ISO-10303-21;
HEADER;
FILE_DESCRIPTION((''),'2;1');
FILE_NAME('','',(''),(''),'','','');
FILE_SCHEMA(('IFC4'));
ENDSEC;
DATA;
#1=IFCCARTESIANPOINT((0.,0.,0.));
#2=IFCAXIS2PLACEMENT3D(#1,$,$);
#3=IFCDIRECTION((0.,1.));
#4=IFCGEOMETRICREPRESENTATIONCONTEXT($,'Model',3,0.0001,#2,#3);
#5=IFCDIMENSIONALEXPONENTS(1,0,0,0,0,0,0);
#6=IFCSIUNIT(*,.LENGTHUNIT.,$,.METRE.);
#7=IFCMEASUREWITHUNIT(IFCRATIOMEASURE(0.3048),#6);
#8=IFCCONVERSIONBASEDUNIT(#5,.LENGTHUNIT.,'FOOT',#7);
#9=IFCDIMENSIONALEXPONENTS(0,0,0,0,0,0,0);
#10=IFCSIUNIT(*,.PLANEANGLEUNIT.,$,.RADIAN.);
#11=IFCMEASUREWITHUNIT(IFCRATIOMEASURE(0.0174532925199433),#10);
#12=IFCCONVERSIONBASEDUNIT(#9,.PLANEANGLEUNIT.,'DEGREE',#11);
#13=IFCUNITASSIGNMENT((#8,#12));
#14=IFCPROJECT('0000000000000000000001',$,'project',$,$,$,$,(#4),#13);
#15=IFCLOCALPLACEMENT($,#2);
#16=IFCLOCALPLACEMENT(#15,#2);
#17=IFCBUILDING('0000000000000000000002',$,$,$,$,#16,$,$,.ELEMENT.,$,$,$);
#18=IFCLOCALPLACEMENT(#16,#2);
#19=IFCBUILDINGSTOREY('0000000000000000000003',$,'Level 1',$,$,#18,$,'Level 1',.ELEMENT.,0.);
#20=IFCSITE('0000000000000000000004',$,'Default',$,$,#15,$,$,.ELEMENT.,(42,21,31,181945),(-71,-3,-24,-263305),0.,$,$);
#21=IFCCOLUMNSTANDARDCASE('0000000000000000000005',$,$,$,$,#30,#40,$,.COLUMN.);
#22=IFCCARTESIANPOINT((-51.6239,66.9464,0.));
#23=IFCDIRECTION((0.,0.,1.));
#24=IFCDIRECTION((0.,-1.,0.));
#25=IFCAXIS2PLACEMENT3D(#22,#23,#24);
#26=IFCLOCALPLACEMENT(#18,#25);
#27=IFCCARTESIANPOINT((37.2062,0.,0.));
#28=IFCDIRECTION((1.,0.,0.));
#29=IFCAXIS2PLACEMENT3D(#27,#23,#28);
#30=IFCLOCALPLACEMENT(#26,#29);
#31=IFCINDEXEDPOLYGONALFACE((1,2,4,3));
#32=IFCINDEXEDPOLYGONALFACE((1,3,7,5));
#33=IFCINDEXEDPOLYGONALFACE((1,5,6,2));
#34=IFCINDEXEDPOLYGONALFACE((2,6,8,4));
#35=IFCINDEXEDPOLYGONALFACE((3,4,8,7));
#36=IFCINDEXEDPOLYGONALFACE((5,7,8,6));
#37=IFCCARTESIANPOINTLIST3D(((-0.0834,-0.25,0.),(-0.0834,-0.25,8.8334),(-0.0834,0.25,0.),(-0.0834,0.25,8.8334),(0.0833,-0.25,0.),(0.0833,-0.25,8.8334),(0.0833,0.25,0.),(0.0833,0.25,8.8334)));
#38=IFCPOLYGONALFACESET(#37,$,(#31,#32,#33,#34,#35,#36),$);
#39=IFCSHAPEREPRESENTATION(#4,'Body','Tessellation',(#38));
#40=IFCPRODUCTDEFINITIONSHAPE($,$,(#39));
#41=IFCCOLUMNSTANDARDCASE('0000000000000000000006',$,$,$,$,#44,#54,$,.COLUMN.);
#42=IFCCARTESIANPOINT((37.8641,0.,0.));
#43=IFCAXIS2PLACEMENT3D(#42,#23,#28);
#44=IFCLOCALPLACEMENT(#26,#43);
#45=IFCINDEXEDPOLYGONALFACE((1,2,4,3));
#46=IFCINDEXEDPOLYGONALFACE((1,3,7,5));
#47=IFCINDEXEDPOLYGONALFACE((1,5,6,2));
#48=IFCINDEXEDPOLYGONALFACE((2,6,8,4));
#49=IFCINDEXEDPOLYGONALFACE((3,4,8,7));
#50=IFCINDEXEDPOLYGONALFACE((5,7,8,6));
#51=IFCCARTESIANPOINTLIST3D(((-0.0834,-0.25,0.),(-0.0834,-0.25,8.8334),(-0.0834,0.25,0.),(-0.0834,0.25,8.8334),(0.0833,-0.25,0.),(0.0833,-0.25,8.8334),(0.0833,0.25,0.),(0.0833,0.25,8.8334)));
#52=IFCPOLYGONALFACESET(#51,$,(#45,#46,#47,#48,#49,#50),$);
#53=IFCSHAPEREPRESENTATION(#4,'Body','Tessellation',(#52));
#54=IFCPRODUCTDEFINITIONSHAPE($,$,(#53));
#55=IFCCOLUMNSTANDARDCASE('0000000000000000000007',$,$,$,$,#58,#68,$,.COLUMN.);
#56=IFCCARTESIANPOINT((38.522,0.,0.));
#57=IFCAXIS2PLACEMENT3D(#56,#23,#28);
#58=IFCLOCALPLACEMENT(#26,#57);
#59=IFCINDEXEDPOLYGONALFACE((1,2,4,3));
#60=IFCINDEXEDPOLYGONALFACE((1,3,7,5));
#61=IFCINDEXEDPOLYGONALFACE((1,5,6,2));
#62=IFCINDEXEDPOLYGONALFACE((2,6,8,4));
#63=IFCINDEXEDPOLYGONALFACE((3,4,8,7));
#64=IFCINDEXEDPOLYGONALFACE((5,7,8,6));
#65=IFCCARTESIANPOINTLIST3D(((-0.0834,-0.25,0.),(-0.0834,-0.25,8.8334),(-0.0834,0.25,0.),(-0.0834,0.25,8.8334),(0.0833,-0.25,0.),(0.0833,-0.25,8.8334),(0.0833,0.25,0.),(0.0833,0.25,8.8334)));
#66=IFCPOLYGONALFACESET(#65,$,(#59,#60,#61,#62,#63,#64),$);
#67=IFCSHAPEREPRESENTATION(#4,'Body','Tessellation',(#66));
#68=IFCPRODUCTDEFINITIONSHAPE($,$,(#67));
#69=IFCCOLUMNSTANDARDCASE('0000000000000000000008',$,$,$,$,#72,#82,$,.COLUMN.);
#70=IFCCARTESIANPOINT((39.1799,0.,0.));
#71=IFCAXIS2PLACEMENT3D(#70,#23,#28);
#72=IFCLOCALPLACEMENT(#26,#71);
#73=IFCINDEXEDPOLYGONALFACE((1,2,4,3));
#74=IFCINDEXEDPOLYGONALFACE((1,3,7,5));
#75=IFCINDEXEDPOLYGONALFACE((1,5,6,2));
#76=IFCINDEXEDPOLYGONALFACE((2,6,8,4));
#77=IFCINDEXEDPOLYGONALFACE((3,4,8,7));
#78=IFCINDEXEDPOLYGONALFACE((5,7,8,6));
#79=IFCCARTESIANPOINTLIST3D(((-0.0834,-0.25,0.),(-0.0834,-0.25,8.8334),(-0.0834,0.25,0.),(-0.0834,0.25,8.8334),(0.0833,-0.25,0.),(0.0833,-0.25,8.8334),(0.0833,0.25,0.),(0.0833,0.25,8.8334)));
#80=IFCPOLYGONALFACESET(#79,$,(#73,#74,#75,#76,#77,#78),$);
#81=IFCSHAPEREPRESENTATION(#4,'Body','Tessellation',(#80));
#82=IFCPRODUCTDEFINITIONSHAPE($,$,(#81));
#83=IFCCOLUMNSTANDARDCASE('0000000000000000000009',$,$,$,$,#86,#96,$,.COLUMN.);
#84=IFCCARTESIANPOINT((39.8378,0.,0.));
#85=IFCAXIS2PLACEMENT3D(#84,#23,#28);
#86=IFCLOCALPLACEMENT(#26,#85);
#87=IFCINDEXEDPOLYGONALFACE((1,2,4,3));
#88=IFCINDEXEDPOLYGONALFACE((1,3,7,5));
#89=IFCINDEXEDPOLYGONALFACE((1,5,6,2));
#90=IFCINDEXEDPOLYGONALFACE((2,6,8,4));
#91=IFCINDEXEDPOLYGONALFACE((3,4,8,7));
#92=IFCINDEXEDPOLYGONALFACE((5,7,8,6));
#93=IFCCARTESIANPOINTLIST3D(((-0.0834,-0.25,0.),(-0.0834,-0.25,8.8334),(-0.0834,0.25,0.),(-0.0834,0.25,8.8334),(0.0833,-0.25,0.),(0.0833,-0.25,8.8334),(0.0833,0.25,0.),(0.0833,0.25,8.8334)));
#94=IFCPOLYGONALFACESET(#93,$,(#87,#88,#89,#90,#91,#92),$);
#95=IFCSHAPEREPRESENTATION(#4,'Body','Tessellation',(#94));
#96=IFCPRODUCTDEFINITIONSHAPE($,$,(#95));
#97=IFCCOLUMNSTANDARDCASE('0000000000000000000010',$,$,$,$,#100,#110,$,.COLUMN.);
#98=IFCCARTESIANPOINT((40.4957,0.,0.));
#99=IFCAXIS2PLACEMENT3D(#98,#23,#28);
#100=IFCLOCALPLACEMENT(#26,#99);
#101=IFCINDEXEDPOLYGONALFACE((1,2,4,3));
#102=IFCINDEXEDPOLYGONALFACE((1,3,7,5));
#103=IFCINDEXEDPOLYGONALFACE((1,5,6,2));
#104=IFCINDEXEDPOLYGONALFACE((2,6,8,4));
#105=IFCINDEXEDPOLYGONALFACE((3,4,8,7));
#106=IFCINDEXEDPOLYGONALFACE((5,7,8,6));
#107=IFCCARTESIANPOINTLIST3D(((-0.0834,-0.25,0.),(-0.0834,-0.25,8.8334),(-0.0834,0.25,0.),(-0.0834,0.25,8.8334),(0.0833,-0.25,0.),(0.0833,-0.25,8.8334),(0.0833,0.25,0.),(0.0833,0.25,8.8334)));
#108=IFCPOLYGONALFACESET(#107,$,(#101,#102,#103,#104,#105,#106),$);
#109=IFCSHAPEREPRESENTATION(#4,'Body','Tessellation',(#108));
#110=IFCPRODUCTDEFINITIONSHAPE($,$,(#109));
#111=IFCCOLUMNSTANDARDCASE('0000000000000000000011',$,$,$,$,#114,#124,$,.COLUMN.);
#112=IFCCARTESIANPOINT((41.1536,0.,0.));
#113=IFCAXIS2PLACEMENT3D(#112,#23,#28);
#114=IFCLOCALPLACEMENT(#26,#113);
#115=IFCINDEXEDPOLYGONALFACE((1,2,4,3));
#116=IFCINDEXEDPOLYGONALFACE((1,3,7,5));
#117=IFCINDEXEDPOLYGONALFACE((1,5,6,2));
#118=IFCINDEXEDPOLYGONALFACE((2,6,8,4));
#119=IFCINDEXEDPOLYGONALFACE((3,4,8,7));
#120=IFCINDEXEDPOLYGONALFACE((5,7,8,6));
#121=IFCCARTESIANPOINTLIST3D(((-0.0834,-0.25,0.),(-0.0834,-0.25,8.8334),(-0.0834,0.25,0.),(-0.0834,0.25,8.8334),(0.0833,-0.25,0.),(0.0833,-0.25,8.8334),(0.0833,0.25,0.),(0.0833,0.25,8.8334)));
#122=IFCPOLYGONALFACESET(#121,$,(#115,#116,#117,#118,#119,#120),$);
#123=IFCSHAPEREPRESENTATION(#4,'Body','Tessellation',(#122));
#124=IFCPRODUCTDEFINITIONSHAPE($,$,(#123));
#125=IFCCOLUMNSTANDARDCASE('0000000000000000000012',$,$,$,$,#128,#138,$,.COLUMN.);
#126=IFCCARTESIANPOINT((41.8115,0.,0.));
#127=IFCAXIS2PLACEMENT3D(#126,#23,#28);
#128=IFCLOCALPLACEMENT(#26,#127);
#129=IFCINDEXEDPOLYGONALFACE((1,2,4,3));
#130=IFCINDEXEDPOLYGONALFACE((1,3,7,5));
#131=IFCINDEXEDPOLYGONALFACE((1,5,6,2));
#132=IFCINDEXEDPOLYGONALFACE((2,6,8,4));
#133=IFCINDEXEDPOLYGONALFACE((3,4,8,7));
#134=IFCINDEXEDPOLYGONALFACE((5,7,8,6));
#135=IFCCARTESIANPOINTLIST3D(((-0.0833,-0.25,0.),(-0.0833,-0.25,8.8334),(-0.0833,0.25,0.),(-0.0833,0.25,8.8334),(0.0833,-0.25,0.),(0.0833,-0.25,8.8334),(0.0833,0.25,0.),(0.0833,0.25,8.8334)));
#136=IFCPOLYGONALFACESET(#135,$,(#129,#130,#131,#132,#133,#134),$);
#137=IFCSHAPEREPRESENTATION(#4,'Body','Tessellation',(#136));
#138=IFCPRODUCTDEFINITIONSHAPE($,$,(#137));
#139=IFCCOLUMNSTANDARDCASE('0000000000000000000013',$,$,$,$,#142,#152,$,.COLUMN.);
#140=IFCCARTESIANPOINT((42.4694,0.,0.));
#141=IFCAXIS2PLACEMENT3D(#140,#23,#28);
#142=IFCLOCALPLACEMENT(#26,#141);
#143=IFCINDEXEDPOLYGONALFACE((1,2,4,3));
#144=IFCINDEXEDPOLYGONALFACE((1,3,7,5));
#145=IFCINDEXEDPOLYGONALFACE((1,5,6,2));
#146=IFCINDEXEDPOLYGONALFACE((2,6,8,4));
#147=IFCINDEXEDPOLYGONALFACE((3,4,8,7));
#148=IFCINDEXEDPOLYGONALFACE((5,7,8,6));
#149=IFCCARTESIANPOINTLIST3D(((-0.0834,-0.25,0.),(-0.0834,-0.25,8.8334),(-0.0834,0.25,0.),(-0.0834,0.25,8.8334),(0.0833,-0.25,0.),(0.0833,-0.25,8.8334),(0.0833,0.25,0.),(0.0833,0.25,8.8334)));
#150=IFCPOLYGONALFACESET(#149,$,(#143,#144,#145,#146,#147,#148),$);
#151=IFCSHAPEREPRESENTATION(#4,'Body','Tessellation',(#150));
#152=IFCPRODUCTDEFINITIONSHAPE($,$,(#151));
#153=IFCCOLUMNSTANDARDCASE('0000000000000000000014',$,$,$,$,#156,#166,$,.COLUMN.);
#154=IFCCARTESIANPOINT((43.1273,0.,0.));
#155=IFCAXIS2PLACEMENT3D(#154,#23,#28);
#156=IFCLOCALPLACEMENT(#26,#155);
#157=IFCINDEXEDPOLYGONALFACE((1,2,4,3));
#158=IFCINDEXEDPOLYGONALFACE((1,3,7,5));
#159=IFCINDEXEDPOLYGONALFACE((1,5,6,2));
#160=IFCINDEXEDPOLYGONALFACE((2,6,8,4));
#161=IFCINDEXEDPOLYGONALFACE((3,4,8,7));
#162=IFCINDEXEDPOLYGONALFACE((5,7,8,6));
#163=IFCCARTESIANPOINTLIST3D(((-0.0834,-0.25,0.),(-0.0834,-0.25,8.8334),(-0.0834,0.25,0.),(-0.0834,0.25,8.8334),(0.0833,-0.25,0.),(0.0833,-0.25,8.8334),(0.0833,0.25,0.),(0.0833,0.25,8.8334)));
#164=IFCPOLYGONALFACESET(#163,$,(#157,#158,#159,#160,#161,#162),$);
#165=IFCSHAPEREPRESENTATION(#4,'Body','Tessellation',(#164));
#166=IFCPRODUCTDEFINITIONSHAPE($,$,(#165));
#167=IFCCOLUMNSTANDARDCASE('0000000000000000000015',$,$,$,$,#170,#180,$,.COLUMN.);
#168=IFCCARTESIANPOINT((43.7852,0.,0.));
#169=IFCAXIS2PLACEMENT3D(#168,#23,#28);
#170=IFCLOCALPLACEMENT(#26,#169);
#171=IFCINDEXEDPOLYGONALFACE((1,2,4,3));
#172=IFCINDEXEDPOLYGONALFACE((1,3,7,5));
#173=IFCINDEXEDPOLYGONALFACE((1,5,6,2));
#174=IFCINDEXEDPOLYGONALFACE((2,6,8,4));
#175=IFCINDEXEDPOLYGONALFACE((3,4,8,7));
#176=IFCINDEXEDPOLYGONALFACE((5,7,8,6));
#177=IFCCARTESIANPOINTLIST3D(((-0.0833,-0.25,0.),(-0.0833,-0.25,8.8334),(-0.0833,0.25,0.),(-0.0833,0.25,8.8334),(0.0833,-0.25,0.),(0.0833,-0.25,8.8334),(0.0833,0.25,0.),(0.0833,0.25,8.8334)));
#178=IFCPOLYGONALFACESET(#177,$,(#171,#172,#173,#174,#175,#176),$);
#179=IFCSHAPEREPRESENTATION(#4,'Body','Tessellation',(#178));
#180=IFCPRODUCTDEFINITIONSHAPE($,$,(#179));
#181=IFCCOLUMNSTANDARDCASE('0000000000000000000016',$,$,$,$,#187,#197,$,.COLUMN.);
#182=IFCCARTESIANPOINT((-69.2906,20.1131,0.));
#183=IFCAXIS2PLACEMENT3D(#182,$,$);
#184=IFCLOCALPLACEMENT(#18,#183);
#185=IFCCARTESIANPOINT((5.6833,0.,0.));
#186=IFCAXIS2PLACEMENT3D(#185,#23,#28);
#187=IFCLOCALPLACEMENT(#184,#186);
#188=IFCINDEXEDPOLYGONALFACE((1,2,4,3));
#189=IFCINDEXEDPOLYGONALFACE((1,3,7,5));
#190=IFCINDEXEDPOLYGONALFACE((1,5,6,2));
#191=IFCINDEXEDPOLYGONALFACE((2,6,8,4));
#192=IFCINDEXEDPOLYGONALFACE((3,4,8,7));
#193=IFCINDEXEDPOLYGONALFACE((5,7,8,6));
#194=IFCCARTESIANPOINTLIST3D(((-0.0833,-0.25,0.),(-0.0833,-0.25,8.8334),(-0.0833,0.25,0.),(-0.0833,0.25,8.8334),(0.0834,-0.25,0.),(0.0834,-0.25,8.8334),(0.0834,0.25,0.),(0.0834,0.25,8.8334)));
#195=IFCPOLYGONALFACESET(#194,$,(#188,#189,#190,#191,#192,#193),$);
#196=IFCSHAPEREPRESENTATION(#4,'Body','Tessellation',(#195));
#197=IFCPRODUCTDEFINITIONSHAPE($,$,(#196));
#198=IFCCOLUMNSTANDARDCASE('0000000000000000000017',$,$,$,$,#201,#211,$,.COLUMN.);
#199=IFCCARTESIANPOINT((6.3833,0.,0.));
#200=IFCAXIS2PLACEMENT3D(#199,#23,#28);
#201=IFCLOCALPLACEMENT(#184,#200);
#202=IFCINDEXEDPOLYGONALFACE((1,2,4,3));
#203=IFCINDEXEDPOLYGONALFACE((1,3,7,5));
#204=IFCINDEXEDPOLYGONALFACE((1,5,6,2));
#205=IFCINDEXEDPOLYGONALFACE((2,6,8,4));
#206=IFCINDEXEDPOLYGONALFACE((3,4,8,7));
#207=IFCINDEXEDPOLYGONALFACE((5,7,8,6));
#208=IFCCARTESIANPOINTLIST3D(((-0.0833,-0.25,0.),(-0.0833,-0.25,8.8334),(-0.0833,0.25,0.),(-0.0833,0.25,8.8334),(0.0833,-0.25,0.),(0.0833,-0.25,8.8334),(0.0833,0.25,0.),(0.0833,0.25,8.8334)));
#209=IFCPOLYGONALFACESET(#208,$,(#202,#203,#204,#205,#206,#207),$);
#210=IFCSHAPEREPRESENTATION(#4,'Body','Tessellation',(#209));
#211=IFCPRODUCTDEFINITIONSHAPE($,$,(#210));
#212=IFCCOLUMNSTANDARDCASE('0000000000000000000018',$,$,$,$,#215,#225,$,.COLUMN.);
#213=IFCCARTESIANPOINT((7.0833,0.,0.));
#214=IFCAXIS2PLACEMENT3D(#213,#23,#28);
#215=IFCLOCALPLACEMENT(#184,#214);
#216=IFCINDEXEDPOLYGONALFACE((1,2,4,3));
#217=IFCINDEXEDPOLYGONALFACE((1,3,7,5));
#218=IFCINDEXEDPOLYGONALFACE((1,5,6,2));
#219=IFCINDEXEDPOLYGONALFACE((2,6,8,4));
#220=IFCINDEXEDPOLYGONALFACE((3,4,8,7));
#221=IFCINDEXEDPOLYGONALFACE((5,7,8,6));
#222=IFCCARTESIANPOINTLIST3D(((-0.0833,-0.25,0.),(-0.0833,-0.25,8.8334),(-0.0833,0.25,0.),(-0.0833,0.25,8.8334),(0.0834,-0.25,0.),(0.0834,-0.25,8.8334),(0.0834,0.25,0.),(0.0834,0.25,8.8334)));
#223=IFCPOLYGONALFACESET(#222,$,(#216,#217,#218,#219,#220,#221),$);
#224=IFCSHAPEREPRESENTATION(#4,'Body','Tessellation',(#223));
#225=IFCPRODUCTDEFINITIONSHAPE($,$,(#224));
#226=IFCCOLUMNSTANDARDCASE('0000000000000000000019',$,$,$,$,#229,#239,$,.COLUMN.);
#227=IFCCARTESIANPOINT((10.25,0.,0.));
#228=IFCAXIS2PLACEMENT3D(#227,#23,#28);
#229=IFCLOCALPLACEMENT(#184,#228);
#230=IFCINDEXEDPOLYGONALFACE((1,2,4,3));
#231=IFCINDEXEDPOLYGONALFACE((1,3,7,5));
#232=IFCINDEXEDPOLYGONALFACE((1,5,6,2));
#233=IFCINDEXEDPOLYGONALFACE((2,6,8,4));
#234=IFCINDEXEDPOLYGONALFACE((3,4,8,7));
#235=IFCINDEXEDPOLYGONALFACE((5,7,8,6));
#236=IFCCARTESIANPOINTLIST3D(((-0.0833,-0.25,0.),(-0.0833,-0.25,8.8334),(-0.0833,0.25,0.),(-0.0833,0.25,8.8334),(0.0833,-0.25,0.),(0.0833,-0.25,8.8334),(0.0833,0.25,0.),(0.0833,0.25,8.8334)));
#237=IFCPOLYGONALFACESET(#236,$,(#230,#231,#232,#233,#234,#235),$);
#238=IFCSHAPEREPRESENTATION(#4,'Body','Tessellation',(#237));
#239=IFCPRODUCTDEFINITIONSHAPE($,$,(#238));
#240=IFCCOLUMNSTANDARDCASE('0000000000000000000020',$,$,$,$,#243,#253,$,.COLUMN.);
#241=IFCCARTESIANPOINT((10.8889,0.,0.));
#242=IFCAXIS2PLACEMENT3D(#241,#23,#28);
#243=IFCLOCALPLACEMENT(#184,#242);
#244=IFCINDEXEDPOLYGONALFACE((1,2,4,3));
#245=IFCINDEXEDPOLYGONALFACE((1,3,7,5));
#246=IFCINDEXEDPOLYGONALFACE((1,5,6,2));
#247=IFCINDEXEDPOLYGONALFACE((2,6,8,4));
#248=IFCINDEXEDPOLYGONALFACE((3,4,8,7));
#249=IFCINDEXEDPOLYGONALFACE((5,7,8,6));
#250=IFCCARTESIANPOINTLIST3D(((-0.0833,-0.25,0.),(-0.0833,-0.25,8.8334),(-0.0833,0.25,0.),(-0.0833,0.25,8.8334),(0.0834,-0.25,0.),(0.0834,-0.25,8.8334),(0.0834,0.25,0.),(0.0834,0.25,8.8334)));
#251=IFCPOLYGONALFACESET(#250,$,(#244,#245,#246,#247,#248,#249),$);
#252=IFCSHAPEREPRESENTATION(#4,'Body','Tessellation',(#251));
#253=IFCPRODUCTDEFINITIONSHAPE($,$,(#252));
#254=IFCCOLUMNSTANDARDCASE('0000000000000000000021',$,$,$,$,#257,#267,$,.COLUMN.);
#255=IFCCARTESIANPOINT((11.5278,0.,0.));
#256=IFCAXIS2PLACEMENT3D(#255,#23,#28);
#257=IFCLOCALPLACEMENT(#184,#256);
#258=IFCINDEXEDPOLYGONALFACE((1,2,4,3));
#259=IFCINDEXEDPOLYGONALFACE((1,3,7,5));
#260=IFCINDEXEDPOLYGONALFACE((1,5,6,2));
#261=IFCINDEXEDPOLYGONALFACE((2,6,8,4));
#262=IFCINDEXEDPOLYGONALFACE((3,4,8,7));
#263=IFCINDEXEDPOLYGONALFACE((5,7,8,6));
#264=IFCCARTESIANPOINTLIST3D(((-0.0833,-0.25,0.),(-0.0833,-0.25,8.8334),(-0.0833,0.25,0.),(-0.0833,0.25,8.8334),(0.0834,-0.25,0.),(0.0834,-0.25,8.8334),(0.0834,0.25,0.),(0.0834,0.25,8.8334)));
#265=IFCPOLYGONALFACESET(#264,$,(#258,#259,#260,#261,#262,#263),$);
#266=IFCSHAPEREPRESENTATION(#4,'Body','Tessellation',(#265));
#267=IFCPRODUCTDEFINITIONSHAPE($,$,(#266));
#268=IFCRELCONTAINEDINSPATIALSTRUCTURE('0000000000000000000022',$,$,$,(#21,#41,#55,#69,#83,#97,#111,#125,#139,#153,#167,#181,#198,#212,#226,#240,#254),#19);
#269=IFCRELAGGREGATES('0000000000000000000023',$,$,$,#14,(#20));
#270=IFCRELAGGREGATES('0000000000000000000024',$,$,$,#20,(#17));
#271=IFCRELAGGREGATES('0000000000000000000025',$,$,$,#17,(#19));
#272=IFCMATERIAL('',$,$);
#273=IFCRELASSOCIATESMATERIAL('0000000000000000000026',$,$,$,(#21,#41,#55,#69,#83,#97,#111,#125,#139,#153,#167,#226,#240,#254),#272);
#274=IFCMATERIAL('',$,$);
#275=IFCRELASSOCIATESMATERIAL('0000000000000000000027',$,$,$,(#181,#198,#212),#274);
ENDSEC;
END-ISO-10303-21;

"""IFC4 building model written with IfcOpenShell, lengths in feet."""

from ifc_helpers import new_model, entity, si_unit, converted_unit, direction, frame, origin, place, context, project, spatial, rectangle, extrude, material, element, save


model = new_model("IFC4")

# Units and contexts
model_context = context("Model", 3, precision=0.0001, world=origin(), true_north=direction((0.0, 1.0)))
ifc_project = project(units=[converted_unit("LENGTHUNIT", "FOOT", entity("IfcRatioMeasure", 0.3048), si_unit("LENGTHUNIT", "METRE"), dimensions=[1, 0, 0, 0, 0, 0, 0]), converted_unit("PLANEANGLEUNIT", "DEGREE", entity("IfcRatioMeasure", 0.0174532925199433), si_unit("PLANEANGLEUNIT", "RADIAN"), dimensions=[0, 0, 0, 0, 0, 0, 0])], contexts=[model_context])

# Site, building, storey
site_placement = place(None, origin())
site = spatial("IfcSite", under=ifc_project, at=site_placement, Name="Default", CompositionType="ELEMENT", RefLatitude=(42, 21, 31, 181945), RefLongitude=(-71, -3, -24, -263305), RefElevation=0.0)
building_placement = place(site_placement, origin())
building = spatial("IfcBuilding", under=site, at=building_placement, CompositionType="ELEMENT")
storey_placement = place(building_placement, origin())
storey = spatial("IfcBuildingStorey", under=building, at=storey_placement, Name="Level 1", LongName="Level 1", CompositionType="ELEMENT", Elevation=0.0)

# Columns
ifc_material_1 = material(Name="")
placement_1 = place(storey_placement, frame((-51.6239, 66.9464, 0.0), z_axis=(0.0, 0.0, 1.0), x_axis=(0.0, -1.0, 0.0)))
for number, where, z_axis, x_axis in (
    (1, (37.2062, 0.0, 0.0), (0.0, 0.0, 1.0), (1.0, 0.0, 0.0)),
    (2, (37.8641, 0.0, 0.0), (0.0, 0.0, 1.0), (1.0, 0.0, 0.0)),
    (3, (38.522, 0.0, 0.0), (0.0, 0.0, 1.0), (1.0, 0.0, 0.0)),
    (4, (39.1799, 0.0, 0.0), (0.0, 0.0, 1.0), (1.0, 0.0, 0.0)),
    (5, (39.8378, 0.0, 0.0), (0.0, 0.0, 1.0), (1.0, 0.0, 0.0)),
    (6, (40.4957, 0.0, 0.0), (0.0, 0.0, 1.0), (1.0, 0.0, 0.0)),
    (7, (41.1536, 0.0, 0.0), (0.0, 0.0, 1.0), (1.0, 0.0, 0.0)),
    (8, (41.8115, 0.0, 0.0), (0.0, 0.0, 1.0), (1.0, 0.0, 0.0)),
    (9, (42.4694, 0.0, 0.0), (0.0, 0.0, 1.0), (1.0, 0.0, 0.0)),
    (10, (43.1273, 0.0, 0.0), (0.0, 0.0, 1.0), (1.0, 0.0, 0.0)),
    (11, (43.7852, 0.0, 0.0), (0.0, 0.0, 1.0), (1.0, 0.0, 0.0)),
):
    element("IfcColumnStandardCase", number, at=place(placement_1, frame(where, z_axis=z_axis, x_axis=x_axis)), inside=storey, material=ifc_material_1, PredefinedType="COLUMN", context=model_context, shape_type="SweptSolid", body=[
        extrude(rectangle(XDim=0.1667, YDim=0.5), origin(), (0.0, 0.0, 1.0), 8.8334),
    ])
ifc_material_2 = material(Name="")
placement_2 = place(storey_placement, frame((-69.2906, 20.1131, 0.0)))
for number, where, z_axis, x_axis in (
    (12, (5.6833, 0.0, 0.0), (0.0, 0.0, 1.0), (1.0, 0.0, 0.0)),
    (13, (6.3833, 0.0, 0.0), (0.0, 0.0, 1.0), (1.0, 0.0, 0.0)),
    (14, (7.0833, 0.0, 0.0), (0.0, 0.0, 1.0), (1.0, 0.0, 0.0)),
):
    element("IfcColumnStandardCase", number, at=place(placement_2, frame(where, z_axis=z_axis, x_axis=x_axis)), inside=storey, material=ifc_material_2, PredefinedType="COLUMN", context=model_context, shape_type="SweptSolid", body=[
        extrude(rectangle(XDim=0.1667, YDim=0.5), origin(), (0.0, 0.0, 1.0), 8.8334),
    ])
for number, where, z_axis, x_axis in (
    (15, (10.25, 0.0, 0.0), (0.0, 0.0, 1.0), (1.0, 0.0, 0.0)),
    (16, (10.8889, 0.0, 0.0), (0.0, 0.0, 1.0), (1.0, 0.0, 0.0)),
    (17, (11.5278, 0.0, 0.0), (0.0, 0.0, 1.0), (1.0, 0.0, 0.0)),
):
    element("IfcColumnStandardCase", number, at=place(placement_2, frame(where, z_axis=z_axis, x_axis=x_axis)), inside=storey, material=ifc_material_1, PredefinedType="COLUMN", context=model_context, shape_type="SweptSolid", body=[
        extrude(rectangle(XDim=0.1667, YDim=0.5), origin(), (0.0, 0.0, 1.0), 8.8334),
    ])

save(model, "model.ifc")
